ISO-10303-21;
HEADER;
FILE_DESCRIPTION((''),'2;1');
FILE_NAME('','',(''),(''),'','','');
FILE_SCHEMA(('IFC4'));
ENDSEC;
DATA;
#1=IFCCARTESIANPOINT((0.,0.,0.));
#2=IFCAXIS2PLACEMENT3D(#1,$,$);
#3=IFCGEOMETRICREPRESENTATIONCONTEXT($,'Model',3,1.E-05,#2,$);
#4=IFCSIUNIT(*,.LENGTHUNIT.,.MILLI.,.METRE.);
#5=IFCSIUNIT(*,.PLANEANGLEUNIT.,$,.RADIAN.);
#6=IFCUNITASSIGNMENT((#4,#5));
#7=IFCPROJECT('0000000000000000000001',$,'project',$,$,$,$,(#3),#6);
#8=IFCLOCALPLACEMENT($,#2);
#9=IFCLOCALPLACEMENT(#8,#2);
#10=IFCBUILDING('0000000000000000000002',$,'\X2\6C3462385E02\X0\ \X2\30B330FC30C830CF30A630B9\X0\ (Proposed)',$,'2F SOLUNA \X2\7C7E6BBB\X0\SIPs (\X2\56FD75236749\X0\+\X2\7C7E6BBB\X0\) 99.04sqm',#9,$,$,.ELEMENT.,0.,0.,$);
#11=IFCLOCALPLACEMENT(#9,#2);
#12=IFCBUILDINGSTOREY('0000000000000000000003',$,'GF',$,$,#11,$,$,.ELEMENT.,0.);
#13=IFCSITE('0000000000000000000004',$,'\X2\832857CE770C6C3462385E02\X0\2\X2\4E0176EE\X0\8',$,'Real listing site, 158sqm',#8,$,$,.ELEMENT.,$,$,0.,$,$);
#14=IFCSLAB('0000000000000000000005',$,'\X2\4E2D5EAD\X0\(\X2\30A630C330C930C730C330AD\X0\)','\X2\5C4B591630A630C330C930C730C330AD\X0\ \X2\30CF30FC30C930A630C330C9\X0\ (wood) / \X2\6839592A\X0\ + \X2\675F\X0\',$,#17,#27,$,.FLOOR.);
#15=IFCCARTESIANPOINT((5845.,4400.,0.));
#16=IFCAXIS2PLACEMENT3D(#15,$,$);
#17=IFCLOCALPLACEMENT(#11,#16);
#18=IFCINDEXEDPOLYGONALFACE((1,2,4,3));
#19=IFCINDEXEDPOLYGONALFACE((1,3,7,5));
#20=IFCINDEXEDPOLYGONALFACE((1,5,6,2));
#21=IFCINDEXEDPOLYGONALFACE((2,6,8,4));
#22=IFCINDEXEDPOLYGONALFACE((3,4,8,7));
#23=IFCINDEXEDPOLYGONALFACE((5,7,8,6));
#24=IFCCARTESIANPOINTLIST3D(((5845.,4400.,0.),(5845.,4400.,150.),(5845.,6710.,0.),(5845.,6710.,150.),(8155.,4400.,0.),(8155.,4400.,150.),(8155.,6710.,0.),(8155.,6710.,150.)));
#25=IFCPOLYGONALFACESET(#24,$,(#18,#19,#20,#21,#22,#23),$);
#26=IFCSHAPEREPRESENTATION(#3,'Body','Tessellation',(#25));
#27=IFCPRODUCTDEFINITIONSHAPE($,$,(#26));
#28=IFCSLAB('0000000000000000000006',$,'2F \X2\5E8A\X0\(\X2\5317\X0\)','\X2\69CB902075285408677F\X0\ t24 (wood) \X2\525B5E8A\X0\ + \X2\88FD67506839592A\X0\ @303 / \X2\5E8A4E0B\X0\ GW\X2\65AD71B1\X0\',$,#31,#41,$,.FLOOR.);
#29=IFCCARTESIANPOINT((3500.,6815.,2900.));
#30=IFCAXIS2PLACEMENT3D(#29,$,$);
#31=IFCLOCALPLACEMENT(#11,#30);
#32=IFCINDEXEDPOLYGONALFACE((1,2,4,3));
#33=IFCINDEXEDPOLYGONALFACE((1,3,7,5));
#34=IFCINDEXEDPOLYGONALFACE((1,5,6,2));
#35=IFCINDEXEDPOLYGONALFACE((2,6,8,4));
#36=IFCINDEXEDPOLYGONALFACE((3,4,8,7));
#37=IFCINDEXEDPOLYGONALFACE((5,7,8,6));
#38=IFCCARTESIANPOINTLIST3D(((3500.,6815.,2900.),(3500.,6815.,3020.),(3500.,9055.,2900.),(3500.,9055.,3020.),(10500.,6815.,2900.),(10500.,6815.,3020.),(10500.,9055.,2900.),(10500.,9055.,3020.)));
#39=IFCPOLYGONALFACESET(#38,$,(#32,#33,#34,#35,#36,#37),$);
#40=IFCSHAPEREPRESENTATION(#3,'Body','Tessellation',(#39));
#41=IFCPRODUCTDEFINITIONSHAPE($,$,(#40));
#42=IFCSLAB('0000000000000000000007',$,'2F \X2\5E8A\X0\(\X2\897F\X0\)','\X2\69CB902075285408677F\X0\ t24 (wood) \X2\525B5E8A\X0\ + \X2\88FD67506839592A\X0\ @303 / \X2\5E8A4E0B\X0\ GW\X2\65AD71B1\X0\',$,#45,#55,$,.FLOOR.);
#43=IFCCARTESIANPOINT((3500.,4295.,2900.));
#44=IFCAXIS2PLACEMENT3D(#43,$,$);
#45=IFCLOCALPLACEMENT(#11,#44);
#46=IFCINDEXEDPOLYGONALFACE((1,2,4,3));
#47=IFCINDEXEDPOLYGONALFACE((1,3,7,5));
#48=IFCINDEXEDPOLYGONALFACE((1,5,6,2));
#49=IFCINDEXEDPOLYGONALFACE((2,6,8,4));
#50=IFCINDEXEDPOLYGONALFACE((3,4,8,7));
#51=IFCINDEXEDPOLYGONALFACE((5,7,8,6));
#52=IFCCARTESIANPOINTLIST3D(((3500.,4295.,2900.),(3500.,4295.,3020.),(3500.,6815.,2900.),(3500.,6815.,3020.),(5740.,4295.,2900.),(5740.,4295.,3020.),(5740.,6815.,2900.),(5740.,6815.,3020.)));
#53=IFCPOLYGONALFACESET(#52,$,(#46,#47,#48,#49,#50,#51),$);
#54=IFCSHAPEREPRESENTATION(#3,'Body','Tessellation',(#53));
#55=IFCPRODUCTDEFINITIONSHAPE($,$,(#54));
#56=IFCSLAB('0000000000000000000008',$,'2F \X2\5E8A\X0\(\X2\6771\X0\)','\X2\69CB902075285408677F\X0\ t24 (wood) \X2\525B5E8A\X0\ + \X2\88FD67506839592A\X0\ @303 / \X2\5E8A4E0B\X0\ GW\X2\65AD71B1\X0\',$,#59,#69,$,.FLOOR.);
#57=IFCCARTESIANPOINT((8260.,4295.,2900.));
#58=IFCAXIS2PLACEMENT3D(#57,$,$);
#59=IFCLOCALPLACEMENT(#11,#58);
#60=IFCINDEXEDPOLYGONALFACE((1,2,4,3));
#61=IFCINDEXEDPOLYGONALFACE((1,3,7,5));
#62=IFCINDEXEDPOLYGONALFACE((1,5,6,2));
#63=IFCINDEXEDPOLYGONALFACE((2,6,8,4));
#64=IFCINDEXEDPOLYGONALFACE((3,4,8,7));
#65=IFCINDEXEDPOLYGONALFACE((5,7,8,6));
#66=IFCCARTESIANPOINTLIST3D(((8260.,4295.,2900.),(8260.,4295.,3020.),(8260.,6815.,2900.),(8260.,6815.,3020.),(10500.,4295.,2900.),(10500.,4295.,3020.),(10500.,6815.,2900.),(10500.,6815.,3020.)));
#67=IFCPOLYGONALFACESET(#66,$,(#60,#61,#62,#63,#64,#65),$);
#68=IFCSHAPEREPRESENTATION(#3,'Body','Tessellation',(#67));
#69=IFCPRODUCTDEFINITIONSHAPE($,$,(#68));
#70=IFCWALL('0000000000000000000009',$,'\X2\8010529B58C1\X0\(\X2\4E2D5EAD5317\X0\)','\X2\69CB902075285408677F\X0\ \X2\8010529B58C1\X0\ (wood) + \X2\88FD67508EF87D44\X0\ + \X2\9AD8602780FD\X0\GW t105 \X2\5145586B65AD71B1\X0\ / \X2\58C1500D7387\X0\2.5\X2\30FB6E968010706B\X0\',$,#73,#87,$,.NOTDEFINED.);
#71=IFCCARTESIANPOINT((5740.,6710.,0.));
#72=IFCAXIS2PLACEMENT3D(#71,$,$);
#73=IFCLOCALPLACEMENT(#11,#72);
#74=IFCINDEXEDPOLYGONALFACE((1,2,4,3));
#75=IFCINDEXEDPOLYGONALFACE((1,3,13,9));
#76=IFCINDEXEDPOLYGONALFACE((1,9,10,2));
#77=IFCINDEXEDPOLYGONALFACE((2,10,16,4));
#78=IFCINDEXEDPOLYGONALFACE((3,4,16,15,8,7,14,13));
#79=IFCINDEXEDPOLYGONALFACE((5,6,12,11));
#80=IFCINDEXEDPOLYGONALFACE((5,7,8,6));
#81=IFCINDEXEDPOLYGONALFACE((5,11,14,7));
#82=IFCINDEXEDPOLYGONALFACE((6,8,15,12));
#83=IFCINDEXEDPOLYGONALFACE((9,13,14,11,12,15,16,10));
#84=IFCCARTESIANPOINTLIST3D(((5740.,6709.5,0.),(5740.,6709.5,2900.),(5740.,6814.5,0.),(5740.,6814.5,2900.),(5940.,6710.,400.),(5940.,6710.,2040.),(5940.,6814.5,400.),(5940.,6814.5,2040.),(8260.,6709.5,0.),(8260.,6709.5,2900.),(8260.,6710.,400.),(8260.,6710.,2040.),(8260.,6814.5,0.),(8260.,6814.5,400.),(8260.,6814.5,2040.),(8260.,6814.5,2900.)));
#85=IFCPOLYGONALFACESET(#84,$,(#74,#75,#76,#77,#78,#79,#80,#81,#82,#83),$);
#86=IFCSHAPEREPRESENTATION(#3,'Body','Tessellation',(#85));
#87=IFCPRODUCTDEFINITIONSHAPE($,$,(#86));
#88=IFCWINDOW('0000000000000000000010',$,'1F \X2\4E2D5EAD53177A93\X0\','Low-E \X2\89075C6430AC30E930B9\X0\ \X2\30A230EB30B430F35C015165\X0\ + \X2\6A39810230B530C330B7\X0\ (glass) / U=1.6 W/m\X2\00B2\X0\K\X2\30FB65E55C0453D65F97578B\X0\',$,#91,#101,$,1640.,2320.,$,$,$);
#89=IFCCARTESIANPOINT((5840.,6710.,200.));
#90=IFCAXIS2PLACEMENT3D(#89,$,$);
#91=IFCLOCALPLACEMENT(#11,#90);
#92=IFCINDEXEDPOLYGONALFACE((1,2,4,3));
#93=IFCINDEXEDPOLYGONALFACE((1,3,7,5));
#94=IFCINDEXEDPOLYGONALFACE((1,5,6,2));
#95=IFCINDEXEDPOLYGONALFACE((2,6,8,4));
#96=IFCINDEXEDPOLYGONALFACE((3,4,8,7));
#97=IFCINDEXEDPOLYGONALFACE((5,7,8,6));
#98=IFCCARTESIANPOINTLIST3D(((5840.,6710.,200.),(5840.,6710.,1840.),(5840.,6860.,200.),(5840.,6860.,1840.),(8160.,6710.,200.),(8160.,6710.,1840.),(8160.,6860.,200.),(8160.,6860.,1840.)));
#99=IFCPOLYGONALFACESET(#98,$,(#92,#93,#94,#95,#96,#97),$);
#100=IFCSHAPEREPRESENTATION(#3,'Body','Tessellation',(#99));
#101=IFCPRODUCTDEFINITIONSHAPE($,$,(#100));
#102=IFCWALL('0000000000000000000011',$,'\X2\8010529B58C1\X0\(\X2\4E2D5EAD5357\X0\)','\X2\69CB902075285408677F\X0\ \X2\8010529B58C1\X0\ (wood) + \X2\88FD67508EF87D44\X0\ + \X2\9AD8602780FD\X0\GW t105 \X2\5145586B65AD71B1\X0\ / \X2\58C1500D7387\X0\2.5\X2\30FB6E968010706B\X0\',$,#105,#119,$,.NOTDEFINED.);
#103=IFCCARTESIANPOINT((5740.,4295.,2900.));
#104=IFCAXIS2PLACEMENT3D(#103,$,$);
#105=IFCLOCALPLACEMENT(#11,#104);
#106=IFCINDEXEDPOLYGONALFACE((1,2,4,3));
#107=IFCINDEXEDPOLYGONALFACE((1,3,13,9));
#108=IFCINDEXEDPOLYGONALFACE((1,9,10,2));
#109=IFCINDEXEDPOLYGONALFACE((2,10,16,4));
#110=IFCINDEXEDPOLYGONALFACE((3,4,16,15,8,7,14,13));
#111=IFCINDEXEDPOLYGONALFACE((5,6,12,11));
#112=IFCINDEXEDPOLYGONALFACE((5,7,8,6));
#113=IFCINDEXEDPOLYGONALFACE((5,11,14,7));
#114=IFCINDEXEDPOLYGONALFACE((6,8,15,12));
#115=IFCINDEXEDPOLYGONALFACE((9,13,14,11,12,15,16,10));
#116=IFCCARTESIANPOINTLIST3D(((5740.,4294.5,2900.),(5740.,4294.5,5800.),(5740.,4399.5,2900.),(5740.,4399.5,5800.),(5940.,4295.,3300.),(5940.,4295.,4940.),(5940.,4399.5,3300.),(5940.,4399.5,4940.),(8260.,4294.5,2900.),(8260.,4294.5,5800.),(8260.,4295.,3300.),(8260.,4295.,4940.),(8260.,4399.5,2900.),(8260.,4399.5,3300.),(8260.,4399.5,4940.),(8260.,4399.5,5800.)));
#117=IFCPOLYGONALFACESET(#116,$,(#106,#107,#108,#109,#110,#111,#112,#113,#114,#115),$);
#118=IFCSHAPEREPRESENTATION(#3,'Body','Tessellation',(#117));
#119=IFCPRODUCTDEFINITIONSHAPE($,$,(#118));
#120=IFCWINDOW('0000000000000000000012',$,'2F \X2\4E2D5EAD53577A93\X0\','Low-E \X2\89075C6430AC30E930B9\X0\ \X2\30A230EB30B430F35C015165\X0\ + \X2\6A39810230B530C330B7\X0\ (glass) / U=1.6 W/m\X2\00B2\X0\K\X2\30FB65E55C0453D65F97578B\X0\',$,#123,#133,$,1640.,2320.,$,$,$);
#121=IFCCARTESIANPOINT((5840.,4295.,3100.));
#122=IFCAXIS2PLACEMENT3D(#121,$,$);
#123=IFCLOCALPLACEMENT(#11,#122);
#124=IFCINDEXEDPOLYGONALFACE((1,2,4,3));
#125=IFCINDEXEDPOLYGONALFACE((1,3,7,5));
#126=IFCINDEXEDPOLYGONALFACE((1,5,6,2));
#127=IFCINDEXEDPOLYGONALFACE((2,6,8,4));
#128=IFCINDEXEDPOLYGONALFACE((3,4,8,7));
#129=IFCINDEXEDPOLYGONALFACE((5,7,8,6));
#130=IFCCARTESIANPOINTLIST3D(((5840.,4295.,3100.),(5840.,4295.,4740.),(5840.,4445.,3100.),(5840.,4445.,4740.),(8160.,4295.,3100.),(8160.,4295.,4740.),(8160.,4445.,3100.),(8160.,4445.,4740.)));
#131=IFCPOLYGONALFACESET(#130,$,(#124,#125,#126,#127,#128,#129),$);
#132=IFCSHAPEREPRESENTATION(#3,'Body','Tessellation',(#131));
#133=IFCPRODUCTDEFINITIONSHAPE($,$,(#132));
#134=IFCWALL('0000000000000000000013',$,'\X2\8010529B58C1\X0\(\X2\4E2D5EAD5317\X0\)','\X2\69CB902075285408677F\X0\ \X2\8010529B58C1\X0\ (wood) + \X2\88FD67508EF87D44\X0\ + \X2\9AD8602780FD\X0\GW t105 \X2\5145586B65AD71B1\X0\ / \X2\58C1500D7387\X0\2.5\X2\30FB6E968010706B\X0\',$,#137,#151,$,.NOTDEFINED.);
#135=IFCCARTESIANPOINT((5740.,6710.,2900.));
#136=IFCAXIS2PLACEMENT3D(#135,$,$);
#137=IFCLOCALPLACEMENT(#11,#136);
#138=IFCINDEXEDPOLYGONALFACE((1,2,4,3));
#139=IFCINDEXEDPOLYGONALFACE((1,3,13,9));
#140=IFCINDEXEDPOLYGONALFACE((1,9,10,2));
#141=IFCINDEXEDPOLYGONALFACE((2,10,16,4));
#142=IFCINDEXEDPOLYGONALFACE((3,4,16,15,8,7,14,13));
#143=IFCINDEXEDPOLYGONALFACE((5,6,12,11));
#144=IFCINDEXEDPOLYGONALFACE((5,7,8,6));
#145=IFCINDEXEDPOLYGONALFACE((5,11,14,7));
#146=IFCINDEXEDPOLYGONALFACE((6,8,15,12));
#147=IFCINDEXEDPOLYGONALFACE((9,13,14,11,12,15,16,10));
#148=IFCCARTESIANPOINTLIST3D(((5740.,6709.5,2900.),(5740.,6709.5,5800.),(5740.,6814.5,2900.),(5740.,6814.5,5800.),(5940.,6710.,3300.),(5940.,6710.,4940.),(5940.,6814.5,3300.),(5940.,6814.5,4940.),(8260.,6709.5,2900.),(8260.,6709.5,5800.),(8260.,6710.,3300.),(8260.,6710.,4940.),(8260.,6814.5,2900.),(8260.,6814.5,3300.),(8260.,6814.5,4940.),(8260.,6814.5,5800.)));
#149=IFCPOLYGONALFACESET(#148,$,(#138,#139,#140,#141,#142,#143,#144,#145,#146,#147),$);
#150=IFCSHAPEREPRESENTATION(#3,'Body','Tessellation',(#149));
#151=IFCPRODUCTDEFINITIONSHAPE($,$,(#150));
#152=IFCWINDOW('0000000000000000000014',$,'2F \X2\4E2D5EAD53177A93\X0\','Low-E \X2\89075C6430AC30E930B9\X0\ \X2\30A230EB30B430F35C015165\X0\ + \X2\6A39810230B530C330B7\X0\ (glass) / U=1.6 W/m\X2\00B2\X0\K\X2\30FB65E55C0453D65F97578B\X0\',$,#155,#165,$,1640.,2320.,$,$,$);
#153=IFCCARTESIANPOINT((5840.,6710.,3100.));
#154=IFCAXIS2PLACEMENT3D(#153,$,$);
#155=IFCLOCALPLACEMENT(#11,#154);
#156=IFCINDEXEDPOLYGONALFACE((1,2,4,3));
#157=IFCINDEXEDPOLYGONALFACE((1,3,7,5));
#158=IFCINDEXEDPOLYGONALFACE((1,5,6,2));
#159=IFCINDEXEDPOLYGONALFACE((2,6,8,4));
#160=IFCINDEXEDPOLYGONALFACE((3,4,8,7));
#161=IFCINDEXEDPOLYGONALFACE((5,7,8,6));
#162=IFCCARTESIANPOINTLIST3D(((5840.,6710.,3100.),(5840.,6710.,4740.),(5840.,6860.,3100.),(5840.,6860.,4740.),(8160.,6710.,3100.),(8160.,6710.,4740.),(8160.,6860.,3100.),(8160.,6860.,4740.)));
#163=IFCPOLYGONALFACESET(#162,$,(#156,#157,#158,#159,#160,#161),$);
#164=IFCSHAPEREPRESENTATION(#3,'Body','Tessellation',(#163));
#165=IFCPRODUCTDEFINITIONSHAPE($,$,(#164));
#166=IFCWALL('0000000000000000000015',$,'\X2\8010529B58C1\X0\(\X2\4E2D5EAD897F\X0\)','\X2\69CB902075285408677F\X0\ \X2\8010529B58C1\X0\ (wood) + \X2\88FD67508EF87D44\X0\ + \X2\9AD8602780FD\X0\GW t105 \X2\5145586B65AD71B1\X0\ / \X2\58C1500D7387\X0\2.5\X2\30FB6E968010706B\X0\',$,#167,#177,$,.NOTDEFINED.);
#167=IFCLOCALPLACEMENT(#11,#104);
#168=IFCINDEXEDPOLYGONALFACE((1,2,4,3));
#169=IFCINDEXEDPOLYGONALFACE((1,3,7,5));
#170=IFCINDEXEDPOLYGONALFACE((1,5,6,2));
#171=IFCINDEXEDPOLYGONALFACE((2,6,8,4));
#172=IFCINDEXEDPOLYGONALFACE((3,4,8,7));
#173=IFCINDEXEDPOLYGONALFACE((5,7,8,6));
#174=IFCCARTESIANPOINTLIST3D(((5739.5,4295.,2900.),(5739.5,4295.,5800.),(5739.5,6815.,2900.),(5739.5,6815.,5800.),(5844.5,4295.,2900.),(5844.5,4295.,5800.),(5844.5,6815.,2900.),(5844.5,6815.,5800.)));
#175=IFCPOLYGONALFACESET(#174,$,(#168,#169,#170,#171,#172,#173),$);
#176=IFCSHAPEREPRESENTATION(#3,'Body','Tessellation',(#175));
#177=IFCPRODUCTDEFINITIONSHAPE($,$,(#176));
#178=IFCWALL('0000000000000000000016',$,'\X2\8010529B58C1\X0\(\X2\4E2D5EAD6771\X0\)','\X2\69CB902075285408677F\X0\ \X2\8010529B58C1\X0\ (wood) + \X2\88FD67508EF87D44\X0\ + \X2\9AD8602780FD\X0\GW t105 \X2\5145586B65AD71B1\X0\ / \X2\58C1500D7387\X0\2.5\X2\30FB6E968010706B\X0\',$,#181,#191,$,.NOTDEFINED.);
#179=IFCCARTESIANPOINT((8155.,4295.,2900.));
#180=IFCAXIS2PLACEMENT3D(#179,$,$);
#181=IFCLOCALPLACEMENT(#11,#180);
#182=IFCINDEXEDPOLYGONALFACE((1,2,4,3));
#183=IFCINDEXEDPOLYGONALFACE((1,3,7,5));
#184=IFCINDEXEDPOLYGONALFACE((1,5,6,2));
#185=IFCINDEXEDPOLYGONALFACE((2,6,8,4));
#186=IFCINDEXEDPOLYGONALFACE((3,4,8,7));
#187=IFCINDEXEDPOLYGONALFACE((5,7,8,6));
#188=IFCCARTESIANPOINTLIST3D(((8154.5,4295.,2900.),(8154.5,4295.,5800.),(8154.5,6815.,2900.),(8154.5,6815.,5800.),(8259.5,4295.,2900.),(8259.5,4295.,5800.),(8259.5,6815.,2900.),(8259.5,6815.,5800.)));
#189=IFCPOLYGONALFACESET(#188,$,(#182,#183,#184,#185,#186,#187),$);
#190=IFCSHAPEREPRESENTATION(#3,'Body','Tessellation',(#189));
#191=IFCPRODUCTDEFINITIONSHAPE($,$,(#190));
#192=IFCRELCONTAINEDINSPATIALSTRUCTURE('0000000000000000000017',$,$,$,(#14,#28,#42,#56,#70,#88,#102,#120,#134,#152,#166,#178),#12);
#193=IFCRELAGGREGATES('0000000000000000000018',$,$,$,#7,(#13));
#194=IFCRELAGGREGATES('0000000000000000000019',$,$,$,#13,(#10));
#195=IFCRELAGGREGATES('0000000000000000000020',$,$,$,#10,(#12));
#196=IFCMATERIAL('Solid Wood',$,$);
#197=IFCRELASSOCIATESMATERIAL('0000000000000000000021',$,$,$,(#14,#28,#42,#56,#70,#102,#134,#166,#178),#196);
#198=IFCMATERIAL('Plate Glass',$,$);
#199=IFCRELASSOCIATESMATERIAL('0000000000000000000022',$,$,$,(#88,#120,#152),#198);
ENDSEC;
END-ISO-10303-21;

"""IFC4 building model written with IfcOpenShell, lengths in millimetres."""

from ifc_helpers import new_model, si_unit, frame, frame_2d, origin, place, context, project, spatial, rectangle, extrude, material, element, fill, save


model = new_model("IFC4")

# Units and contexts
model_context = context("Model", 3, precision=1e-05, world=origin())
ifc_project = project(units=[si_unit("LENGTHUNIT", "METRE", prefix="MILLI"), si_unit("PLANEANGLEUNIT", "RADIAN")], contexts=[model_context])

# Site, building, storey
site_placement = place(None, origin())
site = spatial("IfcSite", under=ifc_project, at=site_placement, Name="茨城県水戸市2丁目8", ObjectType="Real listing site, 158sqm", CompositionType="ELEMENT", RefElevation=0.0)
building_placement = place(site_placement, origin())
building = spatial("IfcBuilding", under=site, at=building_placement, Name="水戸市 コートハウス (Proposed)", ObjectType="2F SOLUNA 籾殻SIPs (国産杉+籾殻) 99.04sqm", CompositionType="ELEMENT", ElevationOfRefHeight=0.0, ElevationOfTerrain=0.0)
storey_placement = place(building_placement, origin())
storey = spatial("IfcBuildingStorey", under=building, at=storey_placement, Name="GF", CompositionType="ELEMENT", Elevation=0.0)

# Slabs
ifc_material_1 = material(Name="Solid Wood")
slab_1_placement = place(storey_placement, frame((5845.0, 4400.0, 0.0)))
element("IfcSlab", 1, at=slab_1_placement, inside=storey, material=ifc_material_1, Name="中庭(ウッドデッキ)", Description="屋外ウッドデッキ ハードウッド (wood) / 根太 + 束", PredefinedType="FLOOR", context=model_context, shape_type="SweptSolid", body=[
    extrude(rectangle(XDim=2310.0, YDim=2310.0, at=frame_2d((1155.0, 1155.0))), frame((5845.0, 4400.0, 0.0)), (0.0, 0.0, 1.0), 150.0),
])
slab_2_placement = place(storey_placement, frame((3500.0, 6815.0, 2900.0)))
element("IfcSlab", 2, at=slab_2_placement, inside=storey, material=ifc_material_1, Name="2F 床(北)", Description="構造用合板 t24 (wood) 剛床 + 製材根太 @303 / 床下 GW断熱", PredefinedType="FLOOR", context=model_context, shape_type="SweptSolid", body=[
    extrude(rectangle(XDim=7000.0, YDim=2240.0, at=frame_2d((3500.0, 1120.0))), frame((3500.0, 6815.0, 2900.0)), (0.0, 0.0, 1.0), 120.0),
])
slab_3_placement = place(storey_placement, frame((3500.0, 4295.0, 2900.0)))
element("IfcSlab", 3, at=slab_3_placement, inside=storey, material=ifc_material_1, Name="2F 床(西)", Description="構造用合板 t24 (wood) 剛床 + 製材根太 @303 / 床下 GW断熱", PredefinedType="FLOOR", context=model_context, shape_type="SweptSolid", body=[
    extrude(rectangle(XDim=2240.0, YDim=2520.0, at=frame_2d((1120.0, 1260.0))), frame((3500.0, 4295.0, 2900.0)), (0.0, 0.0, 1.0), 120.0),
])
slab_4_placement = place(storey_placement, frame((8260.0, 4295.0, 2900.0)))
element("IfcSlab", 4, at=slab_4_placement, inside=storey, material=ifc_material_1, Name="2F 床(東)", Description="構造用合板 t24 (wood) 剛床 + 製材根太 @303 / 床下 GW断熱", PredefinedType="FLOOR", context=model_context, shape_type="SweptSolid", body=[
    extrude(rectangle(XDim=2240.0, YDim=2520.0, at=frame_2d((1120.0, 1260.0))), frame((8260.0, 4295.0, 2900.0)), (0.0, 0.0, 1.0), 120.0),
])

# Wall, opening, window
wall_1_placement = place(storey_placement, frame((5740.0, 6710.0, 0.0)))
wall_1 = element("IfcWall", 5, at=wall_1_placement, inside=storey, material=ifc_material_1, Name="耐力壁(中庭北)", Description="構造用合板 耐力壁 (wood) + 製材軸組 + 高性能GW t105 充填断熱 / 壁倍率2.5・準耐火", PredefinedType="NOTDEFINED", context=model_context, shape_type="SweptSolid", body=[
    extrude(rectangle(XDim=2520.0, YDim=105.0, at=frame_2d((1260.0, 52.0))), frame((5740.0, 6710.0, 0.0)), (0.0, 0.0, 1.0), 2900.0),
])
opening_1_placement = place(storey_placement, frame((5840.0, 6710.0, 200.0)))
opening_1 = element("IfcOpeningElement", 6, at=opening_1_placement, cuts=wall_1, PredefinedType="NOTDEFINED", context=model_context, shape_type="SweptSolid", body=[
    extrude(rectangle(XDim=2320.0, YDim=150.0, at=frame_2d((1160.0, 75.0))), frame((5840.0, 6710.0, 200.0)), (0.0, 0.0, 1.0), 1640.0),
])
ifc_material_2 = material(Name="Plate Glass")
window_1_placement = place(storey_placement, frame((5840.0, 6710.0, 200.0)))
window_1 = element("IfcWindow", 7, at=window_1_placement, inside=storey, material=ifc_material_2, Name="1F 中庭北窓", Description="Low-E 複層ガラス アルゴン封入 + 樹脂サッシ (glass) / U=1.6 W/m²K・日射取得型", OverallHeight=1640.0, OverallWidth=2320.0, context=model_context, shape_type="SweptSolid", body=[
    extrude(rectangle(XDim=2320.0, YDim=150.0, at=frame_2d((1160.0, 75.0))), frame((5840.0, 6710.0, 200.0)), (0.0, 0.0, 1.0), 1640.0),
])
fill(opening_1, window_1)

# Walls, openings, windows
wall_2_placement = place(storey_placement, frame((5740.0, 4295.0, 2900.0)))
wall_2 = element("IfcWall", 8, at=wall_2_placement, inside=storey, material=ifc_material_1, Name="耐力壁(中庭南)", Description="構造用合板 耐力壁 (wood) + 製材軸組 + 高性能GW t105 充填断熱 / 壁倍率2.5・準耐火", PredefinedType="NOTDEFINED", context=model_context, shape_type="SweptSolid", body=[
    extrude(rectangle(XDim=2520.0, YDim=105.0, at=frame_2d((1260.0, 52.0))), frame((5740.0, 4295.0, 2900.0)), (0.0, 0.0, 1.0), 2900.0),
])
opening_2_placement = place(storey_placement, frame((5840.0, 4295.0, 3100.0)))
opening_2 = element("IfcOpeningElement", 9, at=opening_2_placement, cuts=wall_2, PredefinedType="NOTDEFINED", context=model_context, shape_type="SweptSolid", body=[
    extrude(rectangle(XDim=2320.0, YDim=150.0, at=frame_2d((1160.0, 75.0))), frame((5840.0, 4295.0, 3100.0)), (0.0, 0.0, 1.0), 1640.0),
])
window_2_placement = place(storey_placement, frame((5840.0, 4295.0, 3100.0)))
window_2 = element("IfcWindow", 10, at=window_2_placement, inside=storey, material=ifc_material_2, Name="2F 中庭南窓", Description="Low-E 複層ガラス アルゴン封入 + 樹脂サッシ (glass) / U=1.6 W/m²K・日射取得型", OverallHeight=1640.0, OverallWidth=2320.0, context=model_context, shape_type="SweptSolid", body=[
    extrude(rectangle(XDim=2320.0, YDim=150.0, at=frame_2d((1160.0, 75.0))), frame((5840.0, 4295.0, 3100.0)), (0.0, 0.0, 1.0), 1640.0),
])
fill(opening_2, window_2)
wall_3_placement = place(storey_placement, frame((5740.0, 6710.0, 2900.0)))
wall_3 = element("IfcWall", 11, at=wall_3_placement, inside=storey, material=ifc_material_1, Name="耐力壁(中庭北)", Description="構造用合板 耐力壁 (wood) + 製材軸組 + 高性能GW t105 充填断熱 / 壁倍率2.5・準耐火", PredefinedType="NOTDEFINED", context=model_context, shape_type="SweptSolid", body=[
    extrude(rectangle(XDim=2520.0, YDim=105.0, at=frame_2d((1260.0, 52.0))), frame((5740.0, 6710.0, 2900.0)), (0.0, 0.0, 1.0), 2900.0),
])
opening_3_placement = place(storey_placement, frame((5840.0, 6710.0, 3100.0)))
opening_3 = element("IfcOpeningElement", 12, at=opening_3_placement, cuts=wall_3, PredefinedType="NOTDEFINED", context=model_context, shape_type="SweptSolid", body=[
    extrude(rectangle(XDim=2320.0, YDim=150.0, at=frame_2d((1160.0, 75.0))), frame((5840.0, 6710.0, 3100.0)), (0.0, 0.0, 1.0), 1640.0),
])
window_3_placement = place(storey_placement, frame((5840.0, 6710.0, 3100.0)))
window_3 = element("IfcWindow", 13, at=window_3_placement, inside=storey, material=ifc_material_2, Name="2F 中庭北窓", Description="Low-E 複層ガラス アルゴン封入 + 樹脂サッシ (glass) / U=1.6 W/m²K・日射取得型", OverallHeight=1640.0, OverallWidth=2320.0, context=model_context, shape_type="SweptSolid", body=[
    extrude(rectangle(XDim=2320.0, YDim=150.0, at=frame_2d((1160.0, 75.0))), frame((5840.0, 6710.0, 3100.0)), (0.0, 0.0, 1.0), 1640.0),
])
fill(opening_3, window_3)

# Walls
wall_4_placement = place(storey_placement, frame((5740.0, 4295.0, 2900.0)))
element("IfcWall", 14, at=wall_4_placement, inside=storey, material=ifc_material_1, Name="耐力壁(中庭西)", Description="構造用合板 耐力壁 (wood) + 製材軸組 + 高性能GW t105 充填断熱 / 壁倍率2.5・準耐火", PredefinedType="NOTDEFINED", context=model_context, shape_type="SweptSolid", body=[
    extrude(rectangle(XDim=105.0, YDim=2520.0, at=frame_2d((52.0, 1260.0))), frame((5740.0, 4295.0, 2900.0)), (0.0, 0.0, 1.0), 2900.0),
])
wall_5_placement = place(storey_placement, frame((8155.0, 4295.0, 2900.0)))
element("IfcWall", 15, at=wall_5_placement, inside=storey, material=ifc_material_1, Name="耐力壁(中庭東)", Description="構造用合板 耐力壁 (wood) + 製材軸組 + 高性能GW t105 充填断熱 / 壁倍率2.5・準耐火", PredefinedType="NOTDEFINED", context=model_context, shape_type="SweptSolid", body=[
    extrude(rectangle(XDim=105.0, YDim=2520.0, at=frame_2d((52.0, 1260.0))), frame((8155.0, 4295.0, 2900.0)), (0.0, 0.0, 1.0), 2900.0),
])

save(model, "model.ifc")
